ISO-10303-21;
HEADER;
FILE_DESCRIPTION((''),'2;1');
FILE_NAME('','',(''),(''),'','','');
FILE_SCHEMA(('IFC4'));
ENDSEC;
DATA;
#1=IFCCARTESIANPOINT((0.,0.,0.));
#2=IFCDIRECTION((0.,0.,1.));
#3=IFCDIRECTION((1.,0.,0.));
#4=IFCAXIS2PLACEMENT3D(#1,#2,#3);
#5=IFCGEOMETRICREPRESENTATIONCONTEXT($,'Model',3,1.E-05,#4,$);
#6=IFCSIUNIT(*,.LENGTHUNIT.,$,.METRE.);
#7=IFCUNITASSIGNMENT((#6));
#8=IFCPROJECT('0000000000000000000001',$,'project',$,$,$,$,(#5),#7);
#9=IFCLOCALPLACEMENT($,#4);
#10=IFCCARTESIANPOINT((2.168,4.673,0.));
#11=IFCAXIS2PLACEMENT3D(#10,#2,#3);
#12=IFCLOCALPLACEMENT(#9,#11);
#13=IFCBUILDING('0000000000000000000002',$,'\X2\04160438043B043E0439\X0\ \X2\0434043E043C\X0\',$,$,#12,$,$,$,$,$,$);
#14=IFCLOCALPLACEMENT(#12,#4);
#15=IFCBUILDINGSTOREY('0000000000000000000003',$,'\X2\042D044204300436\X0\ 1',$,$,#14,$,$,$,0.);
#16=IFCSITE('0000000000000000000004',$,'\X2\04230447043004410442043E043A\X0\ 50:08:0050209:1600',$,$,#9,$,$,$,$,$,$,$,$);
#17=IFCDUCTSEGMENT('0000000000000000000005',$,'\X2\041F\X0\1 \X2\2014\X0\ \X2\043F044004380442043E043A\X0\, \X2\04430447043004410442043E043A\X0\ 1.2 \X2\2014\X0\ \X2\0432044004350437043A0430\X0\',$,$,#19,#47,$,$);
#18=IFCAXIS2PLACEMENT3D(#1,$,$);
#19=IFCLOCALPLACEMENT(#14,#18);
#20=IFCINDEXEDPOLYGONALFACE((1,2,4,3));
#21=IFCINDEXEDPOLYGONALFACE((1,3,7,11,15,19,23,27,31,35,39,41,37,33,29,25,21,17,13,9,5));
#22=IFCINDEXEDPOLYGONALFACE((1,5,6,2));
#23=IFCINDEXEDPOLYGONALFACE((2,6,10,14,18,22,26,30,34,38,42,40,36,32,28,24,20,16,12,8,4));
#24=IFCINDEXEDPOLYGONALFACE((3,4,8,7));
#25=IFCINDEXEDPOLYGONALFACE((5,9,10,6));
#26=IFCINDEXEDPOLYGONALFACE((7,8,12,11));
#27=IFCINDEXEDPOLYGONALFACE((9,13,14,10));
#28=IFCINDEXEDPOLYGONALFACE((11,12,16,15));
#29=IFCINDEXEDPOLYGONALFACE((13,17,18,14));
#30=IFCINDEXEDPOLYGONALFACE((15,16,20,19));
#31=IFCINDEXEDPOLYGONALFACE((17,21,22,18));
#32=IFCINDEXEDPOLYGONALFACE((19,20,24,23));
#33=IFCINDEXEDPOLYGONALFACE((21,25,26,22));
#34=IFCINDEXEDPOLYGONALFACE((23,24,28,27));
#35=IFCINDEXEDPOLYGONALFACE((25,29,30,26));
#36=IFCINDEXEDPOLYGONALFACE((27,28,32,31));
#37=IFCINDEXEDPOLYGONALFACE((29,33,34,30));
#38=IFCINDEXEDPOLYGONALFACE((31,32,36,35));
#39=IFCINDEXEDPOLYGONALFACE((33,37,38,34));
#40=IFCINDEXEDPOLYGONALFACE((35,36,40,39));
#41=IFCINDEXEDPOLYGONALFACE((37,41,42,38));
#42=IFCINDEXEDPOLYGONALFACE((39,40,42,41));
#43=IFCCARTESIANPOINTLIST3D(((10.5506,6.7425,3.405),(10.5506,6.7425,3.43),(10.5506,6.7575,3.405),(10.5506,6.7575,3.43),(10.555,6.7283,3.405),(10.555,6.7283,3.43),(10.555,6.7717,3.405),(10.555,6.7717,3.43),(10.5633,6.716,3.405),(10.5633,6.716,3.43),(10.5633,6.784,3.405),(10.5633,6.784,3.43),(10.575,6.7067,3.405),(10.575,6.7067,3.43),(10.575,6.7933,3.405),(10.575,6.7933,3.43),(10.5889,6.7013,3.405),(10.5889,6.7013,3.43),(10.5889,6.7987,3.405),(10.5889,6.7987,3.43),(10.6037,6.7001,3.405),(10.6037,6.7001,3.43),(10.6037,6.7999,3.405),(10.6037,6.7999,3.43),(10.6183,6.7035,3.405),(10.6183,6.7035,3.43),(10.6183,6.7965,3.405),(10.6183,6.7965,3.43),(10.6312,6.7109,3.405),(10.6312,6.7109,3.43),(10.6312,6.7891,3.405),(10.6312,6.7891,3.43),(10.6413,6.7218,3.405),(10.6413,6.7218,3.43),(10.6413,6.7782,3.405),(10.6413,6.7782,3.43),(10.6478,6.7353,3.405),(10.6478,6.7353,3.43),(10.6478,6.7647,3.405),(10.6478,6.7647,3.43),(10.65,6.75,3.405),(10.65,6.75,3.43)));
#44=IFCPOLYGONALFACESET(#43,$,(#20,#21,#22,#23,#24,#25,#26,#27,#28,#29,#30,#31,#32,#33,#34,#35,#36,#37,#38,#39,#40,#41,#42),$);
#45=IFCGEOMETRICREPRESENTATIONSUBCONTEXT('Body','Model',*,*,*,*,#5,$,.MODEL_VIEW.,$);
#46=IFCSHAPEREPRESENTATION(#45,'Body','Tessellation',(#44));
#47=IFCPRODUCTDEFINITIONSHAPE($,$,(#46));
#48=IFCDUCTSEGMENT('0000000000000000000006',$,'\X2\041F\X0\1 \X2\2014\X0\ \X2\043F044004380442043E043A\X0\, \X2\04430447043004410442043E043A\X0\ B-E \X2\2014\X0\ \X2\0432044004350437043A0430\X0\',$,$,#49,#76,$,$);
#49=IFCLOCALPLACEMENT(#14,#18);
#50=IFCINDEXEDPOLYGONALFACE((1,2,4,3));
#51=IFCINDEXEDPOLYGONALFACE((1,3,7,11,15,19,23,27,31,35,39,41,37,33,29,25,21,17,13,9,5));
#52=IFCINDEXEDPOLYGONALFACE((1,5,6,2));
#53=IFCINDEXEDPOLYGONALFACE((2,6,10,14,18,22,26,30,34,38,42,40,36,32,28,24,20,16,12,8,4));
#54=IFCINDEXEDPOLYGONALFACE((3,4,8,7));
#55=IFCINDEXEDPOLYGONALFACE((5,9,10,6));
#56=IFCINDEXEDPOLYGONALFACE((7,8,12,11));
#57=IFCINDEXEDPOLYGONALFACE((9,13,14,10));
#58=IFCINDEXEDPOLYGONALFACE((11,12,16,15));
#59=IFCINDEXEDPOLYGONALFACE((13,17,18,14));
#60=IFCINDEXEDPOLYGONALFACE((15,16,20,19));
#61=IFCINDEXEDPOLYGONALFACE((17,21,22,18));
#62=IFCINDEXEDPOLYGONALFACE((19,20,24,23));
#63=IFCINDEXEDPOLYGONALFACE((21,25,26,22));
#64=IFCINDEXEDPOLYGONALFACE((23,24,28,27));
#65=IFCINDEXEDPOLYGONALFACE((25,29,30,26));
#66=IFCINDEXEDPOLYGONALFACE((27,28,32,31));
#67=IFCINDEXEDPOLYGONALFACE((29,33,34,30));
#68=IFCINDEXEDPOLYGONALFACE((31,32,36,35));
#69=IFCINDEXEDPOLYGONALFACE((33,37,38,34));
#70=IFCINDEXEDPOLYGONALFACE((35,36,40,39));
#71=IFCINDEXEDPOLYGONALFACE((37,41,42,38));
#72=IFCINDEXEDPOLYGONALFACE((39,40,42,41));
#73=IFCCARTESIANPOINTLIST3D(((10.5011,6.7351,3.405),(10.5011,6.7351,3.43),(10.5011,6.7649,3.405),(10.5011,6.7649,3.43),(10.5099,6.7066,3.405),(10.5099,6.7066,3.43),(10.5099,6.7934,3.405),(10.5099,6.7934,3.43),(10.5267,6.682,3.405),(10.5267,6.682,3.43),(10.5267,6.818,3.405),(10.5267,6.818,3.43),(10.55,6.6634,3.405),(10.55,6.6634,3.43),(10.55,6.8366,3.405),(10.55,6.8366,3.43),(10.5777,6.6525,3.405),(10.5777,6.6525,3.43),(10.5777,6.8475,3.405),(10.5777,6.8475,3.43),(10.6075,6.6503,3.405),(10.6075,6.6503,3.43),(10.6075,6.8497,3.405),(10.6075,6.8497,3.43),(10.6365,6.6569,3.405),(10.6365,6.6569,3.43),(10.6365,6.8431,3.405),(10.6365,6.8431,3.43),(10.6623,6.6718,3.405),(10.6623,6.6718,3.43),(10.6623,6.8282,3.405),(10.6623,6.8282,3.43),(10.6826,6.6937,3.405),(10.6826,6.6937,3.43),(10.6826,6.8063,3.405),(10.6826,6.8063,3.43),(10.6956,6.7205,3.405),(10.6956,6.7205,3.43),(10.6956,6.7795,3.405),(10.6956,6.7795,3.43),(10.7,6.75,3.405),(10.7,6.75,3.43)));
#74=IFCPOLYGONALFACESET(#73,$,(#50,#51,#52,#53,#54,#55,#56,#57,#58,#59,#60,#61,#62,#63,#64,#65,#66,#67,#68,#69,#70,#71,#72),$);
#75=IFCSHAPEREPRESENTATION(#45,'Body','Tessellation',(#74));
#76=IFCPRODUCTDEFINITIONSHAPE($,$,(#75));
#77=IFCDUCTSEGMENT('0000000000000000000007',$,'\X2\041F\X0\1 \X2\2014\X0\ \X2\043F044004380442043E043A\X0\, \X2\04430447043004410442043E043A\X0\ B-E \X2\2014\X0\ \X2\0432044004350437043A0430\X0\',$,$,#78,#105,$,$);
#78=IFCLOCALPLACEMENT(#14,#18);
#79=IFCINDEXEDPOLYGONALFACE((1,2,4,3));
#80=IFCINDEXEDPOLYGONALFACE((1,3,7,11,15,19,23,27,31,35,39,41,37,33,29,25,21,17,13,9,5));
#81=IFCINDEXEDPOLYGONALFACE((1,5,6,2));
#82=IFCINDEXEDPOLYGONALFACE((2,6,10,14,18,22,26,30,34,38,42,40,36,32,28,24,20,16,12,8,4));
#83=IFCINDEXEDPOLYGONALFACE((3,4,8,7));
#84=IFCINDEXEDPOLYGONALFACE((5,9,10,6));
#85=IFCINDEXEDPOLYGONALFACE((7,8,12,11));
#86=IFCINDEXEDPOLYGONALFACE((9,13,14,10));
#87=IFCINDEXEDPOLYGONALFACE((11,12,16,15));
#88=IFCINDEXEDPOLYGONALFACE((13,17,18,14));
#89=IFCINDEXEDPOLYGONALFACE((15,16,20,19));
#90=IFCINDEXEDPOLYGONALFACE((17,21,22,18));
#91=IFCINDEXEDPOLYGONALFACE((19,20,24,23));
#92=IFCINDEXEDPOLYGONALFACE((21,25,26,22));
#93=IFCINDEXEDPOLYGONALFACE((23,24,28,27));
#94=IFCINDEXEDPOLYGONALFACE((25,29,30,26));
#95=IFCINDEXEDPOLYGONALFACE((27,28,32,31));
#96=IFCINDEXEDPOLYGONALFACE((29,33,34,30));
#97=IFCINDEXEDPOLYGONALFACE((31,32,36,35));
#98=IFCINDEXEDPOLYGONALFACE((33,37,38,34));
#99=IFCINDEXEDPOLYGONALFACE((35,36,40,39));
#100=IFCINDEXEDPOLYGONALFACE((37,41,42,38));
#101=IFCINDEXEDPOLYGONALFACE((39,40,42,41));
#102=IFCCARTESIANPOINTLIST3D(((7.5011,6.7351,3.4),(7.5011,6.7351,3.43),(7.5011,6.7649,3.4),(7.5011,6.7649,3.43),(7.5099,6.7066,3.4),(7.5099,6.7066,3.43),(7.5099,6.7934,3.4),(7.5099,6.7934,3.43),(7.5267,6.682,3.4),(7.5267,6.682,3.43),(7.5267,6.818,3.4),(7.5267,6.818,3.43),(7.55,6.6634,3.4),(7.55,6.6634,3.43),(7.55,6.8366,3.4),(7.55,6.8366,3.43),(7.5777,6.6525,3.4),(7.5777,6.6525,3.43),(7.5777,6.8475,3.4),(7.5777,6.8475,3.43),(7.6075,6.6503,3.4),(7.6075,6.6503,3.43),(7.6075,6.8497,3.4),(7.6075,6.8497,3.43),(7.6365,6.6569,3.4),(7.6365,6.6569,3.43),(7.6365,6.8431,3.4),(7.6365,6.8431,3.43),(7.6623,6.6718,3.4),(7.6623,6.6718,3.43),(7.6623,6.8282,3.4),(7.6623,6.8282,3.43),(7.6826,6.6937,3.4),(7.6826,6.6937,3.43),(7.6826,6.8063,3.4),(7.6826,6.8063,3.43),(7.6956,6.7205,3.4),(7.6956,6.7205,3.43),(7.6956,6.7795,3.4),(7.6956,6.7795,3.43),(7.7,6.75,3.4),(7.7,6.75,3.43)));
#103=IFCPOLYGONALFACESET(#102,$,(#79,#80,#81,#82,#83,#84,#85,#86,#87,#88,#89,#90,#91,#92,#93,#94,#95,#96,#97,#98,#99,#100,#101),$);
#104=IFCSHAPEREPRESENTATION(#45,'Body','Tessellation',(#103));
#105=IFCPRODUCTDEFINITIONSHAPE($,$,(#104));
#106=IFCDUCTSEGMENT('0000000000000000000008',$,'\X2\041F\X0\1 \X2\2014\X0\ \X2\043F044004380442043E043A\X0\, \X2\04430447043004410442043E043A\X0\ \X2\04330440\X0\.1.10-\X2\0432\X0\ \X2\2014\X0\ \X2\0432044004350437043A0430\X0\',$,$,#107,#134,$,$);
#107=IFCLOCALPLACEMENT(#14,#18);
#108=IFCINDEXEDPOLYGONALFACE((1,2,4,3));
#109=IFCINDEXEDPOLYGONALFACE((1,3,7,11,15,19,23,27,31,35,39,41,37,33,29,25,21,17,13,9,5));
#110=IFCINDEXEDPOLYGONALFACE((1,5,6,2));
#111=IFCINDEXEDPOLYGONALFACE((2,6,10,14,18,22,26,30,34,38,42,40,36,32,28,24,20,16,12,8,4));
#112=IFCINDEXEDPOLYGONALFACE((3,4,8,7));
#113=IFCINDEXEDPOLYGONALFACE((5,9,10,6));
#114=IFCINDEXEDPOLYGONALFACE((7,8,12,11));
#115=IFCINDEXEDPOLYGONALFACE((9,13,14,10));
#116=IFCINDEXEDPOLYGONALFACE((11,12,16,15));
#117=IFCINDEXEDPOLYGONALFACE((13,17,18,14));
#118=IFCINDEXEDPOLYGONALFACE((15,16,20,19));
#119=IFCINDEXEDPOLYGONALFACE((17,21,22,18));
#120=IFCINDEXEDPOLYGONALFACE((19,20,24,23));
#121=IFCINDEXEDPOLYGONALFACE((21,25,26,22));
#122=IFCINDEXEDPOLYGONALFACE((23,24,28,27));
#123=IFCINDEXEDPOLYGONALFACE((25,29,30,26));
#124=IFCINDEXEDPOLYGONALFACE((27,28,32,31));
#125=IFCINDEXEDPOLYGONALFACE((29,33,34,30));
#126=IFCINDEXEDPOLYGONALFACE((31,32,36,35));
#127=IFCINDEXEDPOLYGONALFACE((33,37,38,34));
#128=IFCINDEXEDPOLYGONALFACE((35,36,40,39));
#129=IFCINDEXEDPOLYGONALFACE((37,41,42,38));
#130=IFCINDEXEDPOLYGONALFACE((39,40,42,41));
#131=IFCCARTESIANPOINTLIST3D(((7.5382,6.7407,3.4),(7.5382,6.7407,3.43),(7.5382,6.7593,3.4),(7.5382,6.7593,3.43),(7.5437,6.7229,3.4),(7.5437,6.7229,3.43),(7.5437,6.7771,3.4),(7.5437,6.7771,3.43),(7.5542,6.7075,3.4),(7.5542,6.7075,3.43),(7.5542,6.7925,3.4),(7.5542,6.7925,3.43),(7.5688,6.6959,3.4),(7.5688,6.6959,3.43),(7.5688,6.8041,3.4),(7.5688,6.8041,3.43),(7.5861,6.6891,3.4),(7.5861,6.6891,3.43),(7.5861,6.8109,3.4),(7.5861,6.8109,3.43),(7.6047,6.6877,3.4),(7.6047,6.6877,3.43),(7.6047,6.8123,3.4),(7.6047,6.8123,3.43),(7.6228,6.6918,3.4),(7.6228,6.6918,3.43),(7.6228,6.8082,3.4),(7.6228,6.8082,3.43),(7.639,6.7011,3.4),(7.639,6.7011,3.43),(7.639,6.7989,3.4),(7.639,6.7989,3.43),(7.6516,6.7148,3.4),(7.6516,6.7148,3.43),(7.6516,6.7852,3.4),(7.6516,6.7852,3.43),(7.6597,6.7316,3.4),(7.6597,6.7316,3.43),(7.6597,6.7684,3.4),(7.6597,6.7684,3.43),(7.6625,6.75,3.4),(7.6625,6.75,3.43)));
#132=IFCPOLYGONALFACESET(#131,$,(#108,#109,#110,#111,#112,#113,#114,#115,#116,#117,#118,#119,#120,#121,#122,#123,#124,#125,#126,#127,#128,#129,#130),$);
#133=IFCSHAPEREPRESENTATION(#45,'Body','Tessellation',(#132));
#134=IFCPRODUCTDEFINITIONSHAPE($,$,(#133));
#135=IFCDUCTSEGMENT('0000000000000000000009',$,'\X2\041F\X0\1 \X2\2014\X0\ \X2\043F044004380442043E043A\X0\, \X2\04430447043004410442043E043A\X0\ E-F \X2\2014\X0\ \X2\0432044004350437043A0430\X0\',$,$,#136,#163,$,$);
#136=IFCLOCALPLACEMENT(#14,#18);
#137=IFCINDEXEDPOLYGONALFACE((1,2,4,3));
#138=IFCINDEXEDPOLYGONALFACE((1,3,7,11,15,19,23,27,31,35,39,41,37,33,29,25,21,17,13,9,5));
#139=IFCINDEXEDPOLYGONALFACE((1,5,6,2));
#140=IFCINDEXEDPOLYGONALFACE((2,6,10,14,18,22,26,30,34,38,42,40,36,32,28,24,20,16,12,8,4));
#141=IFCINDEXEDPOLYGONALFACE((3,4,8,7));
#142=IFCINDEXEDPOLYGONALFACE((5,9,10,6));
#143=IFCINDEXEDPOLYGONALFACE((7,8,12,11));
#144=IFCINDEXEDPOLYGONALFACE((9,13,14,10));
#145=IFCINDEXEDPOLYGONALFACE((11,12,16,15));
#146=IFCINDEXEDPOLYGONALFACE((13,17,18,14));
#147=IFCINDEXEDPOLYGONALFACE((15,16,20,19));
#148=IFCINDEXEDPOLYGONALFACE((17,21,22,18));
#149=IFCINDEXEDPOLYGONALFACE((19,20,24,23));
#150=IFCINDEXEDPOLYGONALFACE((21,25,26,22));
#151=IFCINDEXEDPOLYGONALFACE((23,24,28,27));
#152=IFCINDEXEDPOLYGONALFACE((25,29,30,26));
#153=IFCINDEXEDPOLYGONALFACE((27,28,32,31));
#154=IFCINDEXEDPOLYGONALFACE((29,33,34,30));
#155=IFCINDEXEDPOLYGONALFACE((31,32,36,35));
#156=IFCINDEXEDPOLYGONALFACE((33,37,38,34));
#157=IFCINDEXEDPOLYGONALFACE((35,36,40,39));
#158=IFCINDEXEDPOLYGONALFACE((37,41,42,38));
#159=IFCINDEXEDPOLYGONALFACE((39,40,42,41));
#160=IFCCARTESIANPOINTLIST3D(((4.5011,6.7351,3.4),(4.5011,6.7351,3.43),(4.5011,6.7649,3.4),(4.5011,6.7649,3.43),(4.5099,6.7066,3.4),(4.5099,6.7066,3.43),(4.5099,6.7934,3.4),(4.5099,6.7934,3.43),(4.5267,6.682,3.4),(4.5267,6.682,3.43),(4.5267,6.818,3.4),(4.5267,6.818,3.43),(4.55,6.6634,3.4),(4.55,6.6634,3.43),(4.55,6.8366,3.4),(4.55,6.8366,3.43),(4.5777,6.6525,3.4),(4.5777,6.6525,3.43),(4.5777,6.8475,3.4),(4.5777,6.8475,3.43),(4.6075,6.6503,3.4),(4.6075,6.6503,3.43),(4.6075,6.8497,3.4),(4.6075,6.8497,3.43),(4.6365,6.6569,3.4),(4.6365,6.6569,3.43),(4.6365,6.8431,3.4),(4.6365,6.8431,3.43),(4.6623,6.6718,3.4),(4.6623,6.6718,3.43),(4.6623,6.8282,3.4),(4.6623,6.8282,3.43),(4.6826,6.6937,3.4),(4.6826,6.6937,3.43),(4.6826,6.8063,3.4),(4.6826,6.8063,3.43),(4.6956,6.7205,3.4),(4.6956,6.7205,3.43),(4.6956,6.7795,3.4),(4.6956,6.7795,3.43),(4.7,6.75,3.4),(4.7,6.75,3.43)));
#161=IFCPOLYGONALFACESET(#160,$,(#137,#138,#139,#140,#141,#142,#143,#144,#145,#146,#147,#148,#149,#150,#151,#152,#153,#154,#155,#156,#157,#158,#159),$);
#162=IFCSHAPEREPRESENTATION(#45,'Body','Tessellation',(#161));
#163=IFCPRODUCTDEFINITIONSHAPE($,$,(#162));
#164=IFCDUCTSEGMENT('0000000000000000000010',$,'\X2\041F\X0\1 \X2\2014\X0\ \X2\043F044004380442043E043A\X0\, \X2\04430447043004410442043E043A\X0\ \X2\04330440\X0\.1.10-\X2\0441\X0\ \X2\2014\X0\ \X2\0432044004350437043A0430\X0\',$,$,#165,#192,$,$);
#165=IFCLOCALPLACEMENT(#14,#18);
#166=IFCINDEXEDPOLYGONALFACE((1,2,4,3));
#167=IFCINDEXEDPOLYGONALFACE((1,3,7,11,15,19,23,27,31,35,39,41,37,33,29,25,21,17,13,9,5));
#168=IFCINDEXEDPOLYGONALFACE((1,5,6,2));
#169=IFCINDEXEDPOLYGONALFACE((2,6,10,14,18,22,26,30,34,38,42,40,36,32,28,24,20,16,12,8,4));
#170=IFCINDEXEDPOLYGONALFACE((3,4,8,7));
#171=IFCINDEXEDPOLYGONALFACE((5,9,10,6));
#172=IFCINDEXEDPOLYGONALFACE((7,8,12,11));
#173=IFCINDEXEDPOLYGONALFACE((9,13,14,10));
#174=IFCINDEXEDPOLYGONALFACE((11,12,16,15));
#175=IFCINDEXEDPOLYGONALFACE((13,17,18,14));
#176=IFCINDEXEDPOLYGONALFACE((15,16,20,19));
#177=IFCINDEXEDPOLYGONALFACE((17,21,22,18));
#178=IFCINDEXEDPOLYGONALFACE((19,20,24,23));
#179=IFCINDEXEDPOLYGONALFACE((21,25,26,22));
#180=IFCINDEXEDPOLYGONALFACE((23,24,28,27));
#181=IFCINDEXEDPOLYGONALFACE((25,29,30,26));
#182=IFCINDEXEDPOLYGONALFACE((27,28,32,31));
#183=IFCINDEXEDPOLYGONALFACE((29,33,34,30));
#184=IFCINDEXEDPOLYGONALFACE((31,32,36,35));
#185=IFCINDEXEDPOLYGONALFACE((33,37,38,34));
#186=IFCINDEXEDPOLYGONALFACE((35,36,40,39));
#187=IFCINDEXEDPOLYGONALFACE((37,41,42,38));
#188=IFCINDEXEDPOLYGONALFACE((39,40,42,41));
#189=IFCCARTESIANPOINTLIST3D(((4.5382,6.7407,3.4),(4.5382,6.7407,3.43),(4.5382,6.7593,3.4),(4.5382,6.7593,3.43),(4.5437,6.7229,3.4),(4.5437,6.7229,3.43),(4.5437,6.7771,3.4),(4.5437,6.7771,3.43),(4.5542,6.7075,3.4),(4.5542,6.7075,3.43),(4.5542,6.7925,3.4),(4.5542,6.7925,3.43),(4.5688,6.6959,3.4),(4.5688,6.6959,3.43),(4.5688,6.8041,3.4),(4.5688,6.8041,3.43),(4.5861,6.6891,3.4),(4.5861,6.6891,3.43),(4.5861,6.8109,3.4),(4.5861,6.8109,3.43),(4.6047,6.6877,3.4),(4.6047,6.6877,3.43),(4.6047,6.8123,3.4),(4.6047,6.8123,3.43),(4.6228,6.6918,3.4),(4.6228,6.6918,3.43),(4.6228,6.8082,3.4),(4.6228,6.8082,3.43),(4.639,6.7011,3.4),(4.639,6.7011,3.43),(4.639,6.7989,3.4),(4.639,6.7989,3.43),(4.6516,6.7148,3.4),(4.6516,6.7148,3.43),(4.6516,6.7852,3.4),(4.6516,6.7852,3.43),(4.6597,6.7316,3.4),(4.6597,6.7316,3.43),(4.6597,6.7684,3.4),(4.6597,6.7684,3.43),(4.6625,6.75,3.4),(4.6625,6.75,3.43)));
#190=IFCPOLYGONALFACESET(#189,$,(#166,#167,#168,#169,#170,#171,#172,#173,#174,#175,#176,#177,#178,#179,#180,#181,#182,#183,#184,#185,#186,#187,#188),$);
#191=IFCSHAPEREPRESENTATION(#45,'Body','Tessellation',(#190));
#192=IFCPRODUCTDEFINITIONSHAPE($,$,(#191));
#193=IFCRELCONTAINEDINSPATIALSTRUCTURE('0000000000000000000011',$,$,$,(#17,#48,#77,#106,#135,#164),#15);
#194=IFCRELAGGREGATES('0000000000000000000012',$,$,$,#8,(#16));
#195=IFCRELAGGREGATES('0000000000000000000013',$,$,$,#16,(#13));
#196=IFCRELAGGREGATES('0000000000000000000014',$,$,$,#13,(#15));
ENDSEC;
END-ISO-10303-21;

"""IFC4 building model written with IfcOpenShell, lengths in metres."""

from ifc_helpers import new_model, si_unit, frame, origin_with_axes, origin_2d, place, context, subcontext, project, spatial, circle, extrude, element, save


model = new_model("IFC4")

# Units and contexts
model_context = context("Model", 3, precision=1e-05, world=origin_with_axes())
body_context = subcontext(model_context, "Body", "Model", "MODEL_VIEW")
ifc_project = project(units=[si_unit("LENGTHUNIT", "METRE")], contexts=[model_context])

# Site, building, storey
site_placement = place(None, origin_with_axes())
site = spatial("IfcSite", under=ifc_project, at=site_placement, Name="Участок 50:08:0050209:1600")
building_placement = place(site_placement, frame((2.168, 4.673, 0.0), z_axis=(0.0, 0.0, 1.0), x_axis=(1.0, 0.0, 0.0)))
building = spatial("IfcBuilding", under=site, at=building_placement, Name="Жилой дом")
storey_placement = place(building_placement, origin_with_axes())
storey = spatial("IfcBuildingStorey", under=building, at=storey_placement, Name="Этаж 1", Elevation=0.0)

# Duct segments
duct_segment_1_placement = place(storey_placement, origin_with_axes())
element("IfcDuctSegment", 1, at=duct_segment_1_placement, inside=storey, Name="П1 — приток, участок 1.2 — врезка", context=body_context, shape_type="SweptSolid", body=[
    extrude(circle(Radius=0.05, at=origin_2d()), frame((10.6, 6.75, 3.43), z_axis=(0.0, 0.0, -1.0), x_axis=(1.0, 0.0, 0.0)), (0.0, 0.0, 1.0), 0.025),
])
duct_segment_2_placement = place(storey_placement, origin_with_axes())
element("IfcDuctSegment", 2, at=duct_segment_2_placement, inside=storey, Name="П1 — приток, участок B-E — врезка", context=body_context, shape_type="SweptSolid", body=[
    extrude(circle(Radius=0.1, at=origin_2d()), frame((10.6, 6.75, 3.43), z_axis=(0.0, 0.0, -1.0), x_axis=(1.0, 0.0, 0.0)), (0.0, 0.0, 1.0), 0.025),
])
duct_segment_3_placement = place(storey_placement, origin_with_axes())
element("IfcDuctSegment", 3, at=duct_segment_3_placement, inside=storey, Name="П1 — приток, участок B-E — врезка", context=body_context, shape_type="SweptSolid", body=[
    extrude(circle(Radius=0.1, at=origin_2d()), frame((7.6, 6.75, 3.43), z_axis=(0.0, 0.0, -1.0), x_axis=(1.0, 0.0, 0.0)), (0.0, 0.0, 1.0), 0.03),
])
duct_segment_4_placement = place(storey_placement, origin_with_axes())
element("IfcDuctSegment", 4, at=duct_segment_4_placement, inside=storey, Name="П1 — приток, участок гр.1.10-в — врезка", context=body_context, shape_type="SweptSolid", body=[
    extrude(circle(Radius=0.0625, at=origin_2d()), frame((7.6, 6.75, 3.4), z_axis=(0.0, 0.0, 1.0), x_axis=(1.0, 0.0, 0.0)), (0.0, 0.0, 1.0), 0.03),
])
duct_segment_5_placement = place(storey_placement, origin_with_axes())
element("IfcDuctSegment", 5, at=duct_segment_5_placement, inside=storey, Name="П1 — приток, участок E-F — врезка", context=body_context, shape_type="SweptSolid", body=[
    extrude(circle(Radius=0.1, at=origin_2d()), frame((4.6, 6.75, 3.43), z_axis=(0.0, 0.0, -1.0), x_axis=(1.0, 0.0, 0.0)), (0.0, 0.0, 1.0), 0.03),
])
duct_segment_6_placement = place(storey_placement, origin_with_axes())
element("IfcDuctSegment", 6, at=duct_segment_6_placement, inside=storey, Name="П1 — приток, участок гр.1.10-с — врезка", context=body_context, shape_type="SweptSolid", body=[
    extrude(circle(Radius=0.0625, at=origin_2d()), frame((4.6, 6.75, 3.4), z_axis=(0.0, 0.0, 1.0), x_axis=(1.0, 0.0, 0.0)), (0.0, 0.0, 1.0), 0.03),
])

save(model, "model.ifc")
